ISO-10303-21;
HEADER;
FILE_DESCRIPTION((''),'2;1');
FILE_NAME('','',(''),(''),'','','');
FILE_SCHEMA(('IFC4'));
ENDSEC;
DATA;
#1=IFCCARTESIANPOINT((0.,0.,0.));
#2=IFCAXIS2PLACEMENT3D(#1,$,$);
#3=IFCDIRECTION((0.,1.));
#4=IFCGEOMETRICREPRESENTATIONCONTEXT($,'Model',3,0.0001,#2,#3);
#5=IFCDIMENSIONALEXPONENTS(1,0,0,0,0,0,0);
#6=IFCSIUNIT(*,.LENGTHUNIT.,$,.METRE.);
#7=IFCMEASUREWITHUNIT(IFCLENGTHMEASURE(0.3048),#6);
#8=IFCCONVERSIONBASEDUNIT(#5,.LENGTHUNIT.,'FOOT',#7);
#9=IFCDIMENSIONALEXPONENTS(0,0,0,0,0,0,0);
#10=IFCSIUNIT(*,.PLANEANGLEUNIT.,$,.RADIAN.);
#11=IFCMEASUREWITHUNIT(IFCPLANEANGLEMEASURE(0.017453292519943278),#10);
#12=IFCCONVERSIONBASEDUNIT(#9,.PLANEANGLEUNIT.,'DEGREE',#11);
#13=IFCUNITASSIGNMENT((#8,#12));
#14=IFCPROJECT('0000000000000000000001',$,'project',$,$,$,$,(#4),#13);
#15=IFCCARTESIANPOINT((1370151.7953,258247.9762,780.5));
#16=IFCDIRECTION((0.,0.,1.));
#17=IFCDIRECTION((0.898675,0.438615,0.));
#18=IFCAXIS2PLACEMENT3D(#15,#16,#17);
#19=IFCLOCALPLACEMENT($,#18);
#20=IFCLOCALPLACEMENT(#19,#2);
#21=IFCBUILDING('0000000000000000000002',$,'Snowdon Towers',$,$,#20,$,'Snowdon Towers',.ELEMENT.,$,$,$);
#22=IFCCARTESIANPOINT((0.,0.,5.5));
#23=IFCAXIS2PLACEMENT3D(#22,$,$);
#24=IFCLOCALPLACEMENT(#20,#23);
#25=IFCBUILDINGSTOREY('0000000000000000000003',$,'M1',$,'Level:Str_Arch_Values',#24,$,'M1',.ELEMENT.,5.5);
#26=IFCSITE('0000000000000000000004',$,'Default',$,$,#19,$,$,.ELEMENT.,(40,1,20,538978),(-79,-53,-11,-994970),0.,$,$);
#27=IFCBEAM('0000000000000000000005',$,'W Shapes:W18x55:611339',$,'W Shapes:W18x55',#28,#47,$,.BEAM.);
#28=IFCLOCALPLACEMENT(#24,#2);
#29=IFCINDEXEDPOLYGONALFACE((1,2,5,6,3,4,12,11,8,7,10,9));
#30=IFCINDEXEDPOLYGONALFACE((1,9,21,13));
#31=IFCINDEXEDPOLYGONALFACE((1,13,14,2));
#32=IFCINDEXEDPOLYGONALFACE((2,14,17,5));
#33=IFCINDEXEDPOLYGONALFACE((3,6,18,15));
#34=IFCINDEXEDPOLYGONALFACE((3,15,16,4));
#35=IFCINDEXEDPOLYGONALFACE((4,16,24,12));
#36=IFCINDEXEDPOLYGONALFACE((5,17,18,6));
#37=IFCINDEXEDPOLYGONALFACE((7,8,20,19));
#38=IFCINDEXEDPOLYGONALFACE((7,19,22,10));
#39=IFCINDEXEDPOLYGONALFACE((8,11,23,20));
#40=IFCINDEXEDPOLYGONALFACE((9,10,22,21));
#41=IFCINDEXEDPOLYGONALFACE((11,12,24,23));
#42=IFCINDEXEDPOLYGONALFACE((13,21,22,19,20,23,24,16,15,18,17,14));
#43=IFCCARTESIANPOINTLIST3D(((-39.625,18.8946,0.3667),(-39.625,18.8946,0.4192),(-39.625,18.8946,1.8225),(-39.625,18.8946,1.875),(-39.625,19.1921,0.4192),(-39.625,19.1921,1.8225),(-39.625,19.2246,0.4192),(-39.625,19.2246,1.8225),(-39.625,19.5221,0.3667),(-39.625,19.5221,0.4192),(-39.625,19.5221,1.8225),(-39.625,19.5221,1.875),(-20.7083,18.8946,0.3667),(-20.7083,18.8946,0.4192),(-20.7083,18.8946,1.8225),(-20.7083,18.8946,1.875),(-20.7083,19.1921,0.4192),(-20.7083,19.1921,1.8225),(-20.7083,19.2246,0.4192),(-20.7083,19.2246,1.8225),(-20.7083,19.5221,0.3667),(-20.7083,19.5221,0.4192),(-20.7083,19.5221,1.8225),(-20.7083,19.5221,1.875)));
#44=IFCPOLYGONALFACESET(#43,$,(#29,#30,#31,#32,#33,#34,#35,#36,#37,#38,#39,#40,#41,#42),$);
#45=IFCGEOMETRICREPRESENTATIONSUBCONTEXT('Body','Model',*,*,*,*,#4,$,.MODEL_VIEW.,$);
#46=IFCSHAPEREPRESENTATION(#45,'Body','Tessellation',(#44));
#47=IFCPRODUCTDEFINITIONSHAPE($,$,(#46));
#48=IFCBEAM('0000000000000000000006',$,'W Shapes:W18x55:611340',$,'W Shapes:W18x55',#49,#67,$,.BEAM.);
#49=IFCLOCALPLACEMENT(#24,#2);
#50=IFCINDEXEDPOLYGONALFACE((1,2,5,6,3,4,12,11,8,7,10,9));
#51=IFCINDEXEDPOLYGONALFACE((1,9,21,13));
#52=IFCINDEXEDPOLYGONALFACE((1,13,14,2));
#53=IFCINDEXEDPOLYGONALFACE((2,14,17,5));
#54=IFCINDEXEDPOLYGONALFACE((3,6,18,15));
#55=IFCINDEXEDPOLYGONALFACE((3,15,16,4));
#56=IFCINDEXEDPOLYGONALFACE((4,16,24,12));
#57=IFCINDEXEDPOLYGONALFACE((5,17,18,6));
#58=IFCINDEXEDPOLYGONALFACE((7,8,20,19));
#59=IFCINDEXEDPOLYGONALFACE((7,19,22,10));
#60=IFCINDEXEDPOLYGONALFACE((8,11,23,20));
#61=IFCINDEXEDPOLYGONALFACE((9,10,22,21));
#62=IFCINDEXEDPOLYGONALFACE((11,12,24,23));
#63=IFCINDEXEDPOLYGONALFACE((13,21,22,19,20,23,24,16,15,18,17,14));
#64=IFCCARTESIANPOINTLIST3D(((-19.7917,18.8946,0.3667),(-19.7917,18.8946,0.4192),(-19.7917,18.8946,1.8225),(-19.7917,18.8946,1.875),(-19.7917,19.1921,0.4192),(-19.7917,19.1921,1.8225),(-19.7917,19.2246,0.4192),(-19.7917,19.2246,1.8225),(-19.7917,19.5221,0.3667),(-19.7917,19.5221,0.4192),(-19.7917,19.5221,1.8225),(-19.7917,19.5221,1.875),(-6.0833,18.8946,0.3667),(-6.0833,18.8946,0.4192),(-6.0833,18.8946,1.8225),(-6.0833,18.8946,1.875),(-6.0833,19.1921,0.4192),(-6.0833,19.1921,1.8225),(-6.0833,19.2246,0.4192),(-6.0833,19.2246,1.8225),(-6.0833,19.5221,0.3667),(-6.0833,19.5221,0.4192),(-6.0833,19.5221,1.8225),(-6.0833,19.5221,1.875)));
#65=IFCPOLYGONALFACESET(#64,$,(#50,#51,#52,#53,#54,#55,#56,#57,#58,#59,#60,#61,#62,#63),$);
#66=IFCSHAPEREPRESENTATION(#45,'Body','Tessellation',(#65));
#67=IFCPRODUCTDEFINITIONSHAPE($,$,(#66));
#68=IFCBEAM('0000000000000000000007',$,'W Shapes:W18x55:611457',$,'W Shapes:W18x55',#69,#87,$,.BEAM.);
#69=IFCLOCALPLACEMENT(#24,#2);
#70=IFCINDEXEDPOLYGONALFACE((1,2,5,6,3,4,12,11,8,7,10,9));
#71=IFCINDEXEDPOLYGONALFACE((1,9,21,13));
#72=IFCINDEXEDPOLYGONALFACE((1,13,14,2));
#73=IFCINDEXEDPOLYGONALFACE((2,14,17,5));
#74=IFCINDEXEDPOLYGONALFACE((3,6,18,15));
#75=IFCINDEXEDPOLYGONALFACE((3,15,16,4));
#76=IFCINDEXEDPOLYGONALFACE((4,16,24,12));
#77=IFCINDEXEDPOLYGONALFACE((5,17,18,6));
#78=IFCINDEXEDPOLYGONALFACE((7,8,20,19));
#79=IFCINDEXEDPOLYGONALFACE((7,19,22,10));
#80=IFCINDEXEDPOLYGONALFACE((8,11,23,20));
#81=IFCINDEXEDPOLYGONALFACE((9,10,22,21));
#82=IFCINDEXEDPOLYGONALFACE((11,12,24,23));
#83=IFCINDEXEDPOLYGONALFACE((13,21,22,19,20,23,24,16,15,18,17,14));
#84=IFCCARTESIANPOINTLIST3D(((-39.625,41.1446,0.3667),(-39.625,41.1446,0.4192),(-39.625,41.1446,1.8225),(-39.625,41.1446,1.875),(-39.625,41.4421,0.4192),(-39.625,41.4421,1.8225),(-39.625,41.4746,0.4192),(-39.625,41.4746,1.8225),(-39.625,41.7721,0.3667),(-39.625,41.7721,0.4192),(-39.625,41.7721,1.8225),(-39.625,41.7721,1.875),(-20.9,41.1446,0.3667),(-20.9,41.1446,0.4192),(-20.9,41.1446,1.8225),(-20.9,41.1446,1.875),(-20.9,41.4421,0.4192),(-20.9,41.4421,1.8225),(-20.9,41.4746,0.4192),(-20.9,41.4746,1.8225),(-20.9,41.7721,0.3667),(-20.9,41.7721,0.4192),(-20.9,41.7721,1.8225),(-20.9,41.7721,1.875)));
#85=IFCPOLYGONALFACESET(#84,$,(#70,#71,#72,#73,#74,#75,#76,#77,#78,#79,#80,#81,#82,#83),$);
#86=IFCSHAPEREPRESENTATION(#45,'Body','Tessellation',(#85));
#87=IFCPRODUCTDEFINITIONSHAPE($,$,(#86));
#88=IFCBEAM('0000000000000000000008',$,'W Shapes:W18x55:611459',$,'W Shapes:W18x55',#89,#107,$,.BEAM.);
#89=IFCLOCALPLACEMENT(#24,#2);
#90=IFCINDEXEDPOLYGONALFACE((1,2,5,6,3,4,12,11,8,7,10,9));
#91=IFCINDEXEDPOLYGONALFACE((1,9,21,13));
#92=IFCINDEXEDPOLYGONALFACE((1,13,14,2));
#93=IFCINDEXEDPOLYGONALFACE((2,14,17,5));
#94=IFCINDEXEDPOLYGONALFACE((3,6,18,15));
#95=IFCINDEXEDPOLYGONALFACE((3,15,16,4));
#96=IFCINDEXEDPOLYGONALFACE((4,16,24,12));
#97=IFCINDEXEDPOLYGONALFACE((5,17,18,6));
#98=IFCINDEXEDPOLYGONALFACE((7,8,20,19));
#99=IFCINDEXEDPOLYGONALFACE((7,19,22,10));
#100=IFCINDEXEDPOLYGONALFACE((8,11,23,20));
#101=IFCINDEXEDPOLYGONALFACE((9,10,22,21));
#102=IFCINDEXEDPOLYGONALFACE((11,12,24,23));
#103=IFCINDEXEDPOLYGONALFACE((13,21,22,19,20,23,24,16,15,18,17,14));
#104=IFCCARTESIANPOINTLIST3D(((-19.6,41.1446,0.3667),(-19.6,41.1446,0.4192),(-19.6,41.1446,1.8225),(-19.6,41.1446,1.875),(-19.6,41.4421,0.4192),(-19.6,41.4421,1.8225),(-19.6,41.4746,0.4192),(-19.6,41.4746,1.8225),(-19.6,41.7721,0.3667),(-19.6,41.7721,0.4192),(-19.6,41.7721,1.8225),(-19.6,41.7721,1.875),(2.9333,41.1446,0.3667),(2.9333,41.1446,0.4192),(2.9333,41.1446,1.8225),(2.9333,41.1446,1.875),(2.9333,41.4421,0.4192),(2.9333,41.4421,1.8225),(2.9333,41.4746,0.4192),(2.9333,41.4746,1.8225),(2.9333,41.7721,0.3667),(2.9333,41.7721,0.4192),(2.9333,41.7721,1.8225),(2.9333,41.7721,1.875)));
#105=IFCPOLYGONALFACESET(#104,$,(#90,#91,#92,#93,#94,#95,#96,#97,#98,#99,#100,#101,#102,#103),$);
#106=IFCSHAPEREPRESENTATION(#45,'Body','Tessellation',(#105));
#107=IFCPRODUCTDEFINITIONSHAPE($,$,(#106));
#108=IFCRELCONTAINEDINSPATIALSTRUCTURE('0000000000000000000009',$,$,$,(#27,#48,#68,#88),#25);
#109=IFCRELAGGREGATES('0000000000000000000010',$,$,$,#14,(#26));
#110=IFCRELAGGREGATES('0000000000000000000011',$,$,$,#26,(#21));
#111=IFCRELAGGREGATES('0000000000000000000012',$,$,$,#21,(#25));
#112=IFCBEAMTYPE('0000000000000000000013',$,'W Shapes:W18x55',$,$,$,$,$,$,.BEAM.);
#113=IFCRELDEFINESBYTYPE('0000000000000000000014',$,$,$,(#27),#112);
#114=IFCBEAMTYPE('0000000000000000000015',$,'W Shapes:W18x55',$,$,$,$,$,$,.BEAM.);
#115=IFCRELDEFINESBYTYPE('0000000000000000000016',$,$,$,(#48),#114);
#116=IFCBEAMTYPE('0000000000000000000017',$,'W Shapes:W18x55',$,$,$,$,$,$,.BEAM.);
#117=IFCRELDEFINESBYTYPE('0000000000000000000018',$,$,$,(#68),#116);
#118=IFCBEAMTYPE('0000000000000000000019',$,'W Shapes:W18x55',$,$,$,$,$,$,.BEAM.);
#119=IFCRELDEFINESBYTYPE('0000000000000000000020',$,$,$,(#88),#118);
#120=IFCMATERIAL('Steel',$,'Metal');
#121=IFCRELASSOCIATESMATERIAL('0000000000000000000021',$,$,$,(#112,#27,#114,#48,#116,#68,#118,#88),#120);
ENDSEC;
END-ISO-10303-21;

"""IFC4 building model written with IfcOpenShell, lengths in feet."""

from ifc_helpers import new_model, entity, si_unit, converted_unit, direction, frame, origin, place, context, subcontext, project, spatial, indexed_curve, outline, extrude, source, transform, mapped, material, type_object, type_shapes, element, save


model = new_model("IFC4")

# Units and contexts
model_context = context("Model", 3, precision=0.0001, world=origin(), true_north=direction((0.0, 1.0)))
body_context = subcontext(model_context, "Body", "Model", "MODEL_VIEW")
ifc_project = project(units=[converted_unit("LENGTHUNIT", "FOOT", entity("IfcLengthMeasure", 0.3048), si_unit("LENGTHUNIT", "METRE"), dimensions=[1, 0, 0, 0, 0, 0, 0]), converted_unit("PLANEANGLEUNIT", "DEGREE", entity("IfcPlaneAngleMeasure", 0.017453292519943278), si_unit("PLANEANGLEUNIT", "RADIAN"), dimensions=[0, 0, 0, 0, 0, 0, 0])], contexts=[model_context])

# Site, building, storey
site_placement = place(None, frame((1370151.7953, 258247.9762, 780.5), z_axis=(0.0, 0.0, 1.0), x_axis=(0.898675, 0.438615, 0.0)))
site = spatial("IfcSite", under=ifc_project, at=site_placement, Name="Default", CompositionType="ELEMENT", RefLatitude=(40, 1, 20, 538978), RefLongitude=(-79, -53, -11, -994970), RefElevation=0.0)
building_placement = place(site_placement, origin())
building = spatial("IfcBuilding", under=site, at=building_placement, Name="Snowdon Towers", LongName="Snowdon Towers", CompositionType="ELEMENT")
storey_placement = place(building_placement, frame((0.0, 0.0, 5.5)))
storey = spatial("IfcBuildingStorey", under=building, at=storey_placement, Name="M1", ObjectType="Level:Str_Arch_Values", LongName="M1", CompositionType="ELEMENT", Elevation=5.5)

# Shared definitions
ifc_material = material(Name="Steel", Category="Metal")

# Beams
beam_type_1 = type_object("IfcBeamType", Name="W Shapes:W18x55", PredefinedType="BEAM", material=ifc_material)
shared_shape_1 = source(origin(), body_context, "Body", "SweptSolid", [
    extrude(outline(indexed_curve([(-0.3138, -0.7017), (-0.3138, -0.7542), (0.3138, -0.7542), (0.3138, -0.7017), (0.0162, -0.7017), (0.0162, 0.7017), (0.3138, 0.7017), (0.3138, 0.7542), (-0.3137, 0.7542), (-0.3137, 0.7017), (-0.0163, 0.7017), (-0.0163, -0.7017), (-0.3138, -0.7017)], self_intersect=False)), frame((-9.5625, 0.0, 0.0), z_axis=(-1.0, 0.0, 0.0), x_axis=(0.0, -1.0, 0.0)), (0.0, 0.0, -1.0), 18.9167),
])
type_shapes(beam_type_1, [shared_shape_1])
beam_1_placement = place(storey_placement, frame((-30.0625, 19.2083, 1.1208)))
element("IfcBeam", 1, at=beam_1_placement, inside=storey, type_object=beam_type_1, material=ifc_material, Name="W Shapes:W18x55:611339", ObjectType="W Shapes:W18x55", PredefinedType="BEAM", context=body_context, shape_type="MappedRepresentation", body=[
    mapped(shared_shape_1, transform((0.0, 0.0, 0.0), scale=1.0)),
])
beam_type_2 = type_object("IfcBeamType", Name="W Shapes:W18x55", PredefinedType="BEAM", material=ifc_material)
shared_shape_2 = source(origin(), body_context, "Body", "SweptSolid", [
    extrude(outline(indexed_curve([(-0.3138, -0.7017), (-0.3138, -0.7542), (0.3138, -0.7542), (0.3138, -0.7017), (0.0162, -0.7017), (0.0162, 0.7017), (0.3138, 0.7017), (0.3138, 0.7542), (-0.3137, 0.7542), (-0.3137, 0.7017), (-0.0163, 0.7017), (-0.0163, -0.7017), (-0.3138, -0.7017)], self_intersect=False)), frame((-6.625, 0.0, 0.0), z_axis=(-1.0, 0.0, 0.0), x_axis=(0.0, -1.0, 0.0)), (0.0, 0.0, -1.0), 13.7083),
])
type_shapes(beam_type_2, [shared_shape_2])
beam_2_placement = place(storey_placement, frame((-13.1667, 19.2083, 1.1208)))
element("IfcBeam", 2, at=beam_2_placement, inside=storey, type_object=beam_type_2, material=ifc_material, Name="W Shapes:W18x55:611340", ObjectType="W Shapes:W18x55", PredefinedType="BEAM", context=body_context, shape_type="MappedRepresentation", body=[
    mapped(shared_shape_2, transform((0.0, 0.0, 0.0), scale=1.0)),
])
beam_type_3 = type_object("IfcBeamType", Name="W Shapes:W18x55", PredefinedType="BEAM", material=ifc_material)
shared_shape_3 = source(origin(), body_context, "Body", "SweptSolid", [
    extrude(outline(indexed_curve([(-0.3138, -0.7017), (-0.3138, -0.7542), (0.3138, -0.7542), (0.3138, -0.7017), (0.0162, -0.7017), (0.0162, 0.7017), (0.3138, 0.7017), (0.3138, 0.7542), (-0.3137, 0.7542), (-0.3137, 0.7017), (-0.0163, 0.7017), (-0.0163, -0.7017), (-0.3138, -0.7017)], self_intersect=False)), frame((-9.5625, 0.0, 0.0), z_axis=(-1.0, 0.0, 0.0), x_axis=(0.0, -1.0, 0.0)), (0.0, 0.0, -1.0), 18.725),
])
type_shapes(beam_type_3, [shared_shape_3])
beam_3_placement = place(storey_placement, frame((-30.0625, 41.4583, 1.1208)))
element("IfcBeam", 3, at=beam_3_placement, inside=storey, type_object=beam_type_3, material=ifc_material, Name="W Shapes:W18x55:611457", ObjectType="W Shapes:W18x55", PredefinedType="BEAM", context=body_context, shape_type="MappedRepresentation", body=[
    mapped(shared_shape_3, transform((0.0, 0.0, 0.0), scale=1.0)),
])
beam_type_4 = type_object("IfcBeamType", Name="W Shapes:W18x55", PredefinedType="BEAM", material=ifc_material)
shared_shape_4 = source(origin(), body_context, "Body", "SweptSolid", [
    extrude(outline(indexed_curve([(-0.3138, -0.7017), (-0.3138, -0.7542), (0.3138, -0.7542), (0.3138, -0.7017), (0.0162, -0.7017), (0.0162, 0.7017), (0.3138, 0.7017), (0.3138, 0.7542), (-0.3137, 0.7542), (-0.3137, 0.7017), (-0.0163, 0.7017), (-0.0163, -0.7017), (-0.3138, -0.7017)], self_intersect=False)), frame((-11.35, 0.0, 0.0), z_axis=(-1.0, 0.0, 0.0), x_axis=(0.0, -1.0, 0.0)), (0.0, 0.0, -1.0), 22.5333),
])
type_shapes(beam_type_4, [shared_shape_4])
beam_4_placement = place(storey_placement, frame((-8.25, 41.4583, 1.1208)))
element("IfcBeam", 4, at=beam_4_placement, inside=storey, type_object=beam_type_4, material=ifc_material, Name="W Shapes:W18x55:611459", ObjectType="W Shapes:W18x55", PredefinedType="BEAM", context=body_context, shape_type="MappedRepresentation", body=[
    mapped(shared_shape_4, transform((0.0, 0.0, 0.0), scale=1.0)),
])

save(model, "model.ifc")
